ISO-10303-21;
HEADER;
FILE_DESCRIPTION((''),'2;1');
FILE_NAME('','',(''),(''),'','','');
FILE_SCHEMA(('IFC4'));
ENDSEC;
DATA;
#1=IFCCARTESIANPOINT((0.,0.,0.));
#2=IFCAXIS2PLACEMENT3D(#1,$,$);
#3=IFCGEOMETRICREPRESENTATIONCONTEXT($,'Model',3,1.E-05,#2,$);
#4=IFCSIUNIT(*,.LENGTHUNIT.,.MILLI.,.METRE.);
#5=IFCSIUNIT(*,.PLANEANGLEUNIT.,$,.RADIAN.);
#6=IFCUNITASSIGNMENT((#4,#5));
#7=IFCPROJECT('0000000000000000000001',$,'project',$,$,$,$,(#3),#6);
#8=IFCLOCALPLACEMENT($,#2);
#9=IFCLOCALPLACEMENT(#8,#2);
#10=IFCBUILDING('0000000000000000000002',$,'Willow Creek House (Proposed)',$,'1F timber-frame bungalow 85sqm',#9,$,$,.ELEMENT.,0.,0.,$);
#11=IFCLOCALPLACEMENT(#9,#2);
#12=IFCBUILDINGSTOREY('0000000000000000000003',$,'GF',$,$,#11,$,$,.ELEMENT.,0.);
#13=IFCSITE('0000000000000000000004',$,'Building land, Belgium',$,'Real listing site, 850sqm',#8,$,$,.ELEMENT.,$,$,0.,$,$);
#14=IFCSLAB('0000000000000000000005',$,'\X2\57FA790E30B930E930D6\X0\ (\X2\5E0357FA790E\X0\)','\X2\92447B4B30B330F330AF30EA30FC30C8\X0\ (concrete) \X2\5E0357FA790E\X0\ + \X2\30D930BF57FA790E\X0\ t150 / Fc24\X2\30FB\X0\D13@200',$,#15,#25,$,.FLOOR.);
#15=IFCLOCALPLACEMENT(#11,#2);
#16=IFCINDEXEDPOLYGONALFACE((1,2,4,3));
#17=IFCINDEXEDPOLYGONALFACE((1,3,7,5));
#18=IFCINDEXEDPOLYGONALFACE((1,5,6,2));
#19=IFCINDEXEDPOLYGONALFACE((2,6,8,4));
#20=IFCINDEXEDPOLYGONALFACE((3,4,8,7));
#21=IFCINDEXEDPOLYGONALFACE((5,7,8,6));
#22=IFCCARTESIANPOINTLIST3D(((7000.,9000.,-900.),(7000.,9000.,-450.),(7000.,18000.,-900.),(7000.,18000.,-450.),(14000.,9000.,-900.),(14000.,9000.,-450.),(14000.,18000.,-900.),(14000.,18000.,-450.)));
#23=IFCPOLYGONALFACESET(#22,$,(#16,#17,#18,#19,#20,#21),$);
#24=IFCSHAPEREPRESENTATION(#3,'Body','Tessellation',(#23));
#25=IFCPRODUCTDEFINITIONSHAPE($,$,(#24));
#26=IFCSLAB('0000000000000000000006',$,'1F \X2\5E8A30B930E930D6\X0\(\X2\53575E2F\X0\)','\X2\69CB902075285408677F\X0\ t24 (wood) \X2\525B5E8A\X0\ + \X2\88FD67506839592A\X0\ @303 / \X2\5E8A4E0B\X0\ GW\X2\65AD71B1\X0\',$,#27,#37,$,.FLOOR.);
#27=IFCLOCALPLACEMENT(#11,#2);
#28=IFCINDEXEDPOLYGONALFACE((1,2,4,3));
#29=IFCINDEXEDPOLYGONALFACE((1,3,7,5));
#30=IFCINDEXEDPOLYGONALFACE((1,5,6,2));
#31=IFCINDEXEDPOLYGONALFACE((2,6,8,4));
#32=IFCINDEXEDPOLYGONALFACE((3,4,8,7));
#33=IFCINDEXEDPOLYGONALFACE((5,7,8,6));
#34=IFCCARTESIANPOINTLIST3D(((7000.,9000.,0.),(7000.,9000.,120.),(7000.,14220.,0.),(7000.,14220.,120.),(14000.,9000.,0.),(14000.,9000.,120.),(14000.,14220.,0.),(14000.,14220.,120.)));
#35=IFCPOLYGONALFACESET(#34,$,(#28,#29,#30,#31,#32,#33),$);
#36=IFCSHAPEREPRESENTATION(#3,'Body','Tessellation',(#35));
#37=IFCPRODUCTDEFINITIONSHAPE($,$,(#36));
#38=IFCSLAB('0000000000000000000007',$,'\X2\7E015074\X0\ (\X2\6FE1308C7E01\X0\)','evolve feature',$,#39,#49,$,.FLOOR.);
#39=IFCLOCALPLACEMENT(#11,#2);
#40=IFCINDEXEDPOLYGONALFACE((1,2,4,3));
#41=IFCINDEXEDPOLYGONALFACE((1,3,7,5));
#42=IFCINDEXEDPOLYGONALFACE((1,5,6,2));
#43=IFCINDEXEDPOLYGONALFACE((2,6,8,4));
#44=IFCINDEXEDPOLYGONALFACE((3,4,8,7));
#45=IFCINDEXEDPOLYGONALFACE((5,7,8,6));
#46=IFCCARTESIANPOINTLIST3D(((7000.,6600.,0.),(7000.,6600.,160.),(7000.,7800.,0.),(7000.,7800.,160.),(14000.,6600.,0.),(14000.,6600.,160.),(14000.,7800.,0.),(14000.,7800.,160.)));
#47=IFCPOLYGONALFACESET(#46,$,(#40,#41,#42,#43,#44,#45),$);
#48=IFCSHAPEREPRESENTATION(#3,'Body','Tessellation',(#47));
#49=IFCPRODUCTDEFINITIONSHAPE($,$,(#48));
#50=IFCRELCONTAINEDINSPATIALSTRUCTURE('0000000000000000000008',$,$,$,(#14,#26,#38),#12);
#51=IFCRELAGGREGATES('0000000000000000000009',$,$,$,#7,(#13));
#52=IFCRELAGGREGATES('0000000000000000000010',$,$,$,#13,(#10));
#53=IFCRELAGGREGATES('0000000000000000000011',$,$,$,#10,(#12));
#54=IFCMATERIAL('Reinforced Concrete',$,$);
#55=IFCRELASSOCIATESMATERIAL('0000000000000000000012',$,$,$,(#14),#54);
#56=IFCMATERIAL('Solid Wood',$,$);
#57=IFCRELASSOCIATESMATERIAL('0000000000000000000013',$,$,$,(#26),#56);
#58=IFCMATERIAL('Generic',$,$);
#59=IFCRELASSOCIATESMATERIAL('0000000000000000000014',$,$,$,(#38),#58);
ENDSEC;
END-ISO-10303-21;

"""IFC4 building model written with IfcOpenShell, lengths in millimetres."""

from ifc_helpers import new_model, si_unit, frame, frame_2d, origin, place, context, project, spatial, rectangle, extrude, material, element, save


model = new_model("IFC4")

# Units and contexts
model_context = context("Model", 3, precision=1e-05, world=origin())
ifc_project = project(units=[si_unit("LENGTHUNIT", "METRE", prefix="MILLI"), si_unit("PLANEANGLEUNIT", "RADIAN")], contexts=[model_context])

# Site, building, storey
site_placement = place(None, origin())
site = spatial("IfcSite", under=ifc_project, at=site_placement, Name="Building land, Belgium", ObjectType="Real listing site, 850sqm", CompositionType="ELEMENT", RefElevation=0.0)
building_placement = place(site_placement, origin())
building = spatial("IfcBuilding", under=site, at=building_placement, Name="Willow Creek House (Proposed)", ObjectType="1F timber-frame bungalow 85sqm", CompositionType="ELEMENT", ElevationOfRefHeight=0.0, ElevationOfTerrain=0.0)
storey_placement = place(building_placement, origin())
storey = spatial("IfcBuildingStorey", under=building, at=storey_placement, Name="GF", CompositionType="ELEMENT", Elevation=0.0)

# Slabs
ifc_material_1 = material(Name="Reinforced Concrete")
slab_1_placement = place(storey_placement, frame((3500.0, 4500.0, -450.0)))
element("IfcSlab", 1, at=slab_1_placement, inside=storey, material=ifc_material_1, Name="基礎スラブ (布基礎)", Description="鉄筋コンクリート (concrete) 布基礎 + ベタ基礎 t150 / Fc24・D13@200", PredefinedType="FLOOR", context=model_context, shape_type="SweptSolid", body=[
    extrude(rectangle(XDim=7000.0, YDim=9000.0, at=frame_2d((3500.0, 4500.0))), frame((3500.0, 4500.0, -450.0)), (0.0, 0.0, 1.0), 450.0),
])
ifc_material_2 = material(Name="Solid Wood")
slab_2_placement = place(storey_placement, frame((3500.0, 4500.0, 0.0)))
element("IfcSlab", 2, at=slab_2_placement, inside=storey, material=ifc_material_2, Name="1F 床スラブ(南帯)", Description="構造用合板 t24 (wood) 剛床 + 製材根太 @303 / 床下 GW断熱", PredefinedType="FLOOR", context=model_context, shape_type="SweptSolid", body=[
    extrude(rectangle(XDim=7000.0, YDim=5220.0, at=frame_2d((3500.0, 2610.0))), frame((3500.0, 4500.0, 0.0)), (0.0, 0.0, 1.0), 120.0),
])
ifc_material_3 = material(Name="Generic")
slab_3_placement = place(storey_placement, frame((3500.0, 3300.0, 0.0)))
element("IfcSlab", 3, at=slab_3_placement, inside=storey, material=ifc_material_3, Name="縁側 (濡れ縁)", Description="evolve feature", PredefinedType="FLOOR", context=model_context, shape_type="SweptSolid", body=[
    extrude(rectangle(XDim=7000.0, YDim=1200.0, at=frame_2d((3500.0, 600.0))), frame((3500.0, 3300.0, 0.0)), (0.0, 0.0, 1.0), 160.0),
])

save(model, "model.ifc")
